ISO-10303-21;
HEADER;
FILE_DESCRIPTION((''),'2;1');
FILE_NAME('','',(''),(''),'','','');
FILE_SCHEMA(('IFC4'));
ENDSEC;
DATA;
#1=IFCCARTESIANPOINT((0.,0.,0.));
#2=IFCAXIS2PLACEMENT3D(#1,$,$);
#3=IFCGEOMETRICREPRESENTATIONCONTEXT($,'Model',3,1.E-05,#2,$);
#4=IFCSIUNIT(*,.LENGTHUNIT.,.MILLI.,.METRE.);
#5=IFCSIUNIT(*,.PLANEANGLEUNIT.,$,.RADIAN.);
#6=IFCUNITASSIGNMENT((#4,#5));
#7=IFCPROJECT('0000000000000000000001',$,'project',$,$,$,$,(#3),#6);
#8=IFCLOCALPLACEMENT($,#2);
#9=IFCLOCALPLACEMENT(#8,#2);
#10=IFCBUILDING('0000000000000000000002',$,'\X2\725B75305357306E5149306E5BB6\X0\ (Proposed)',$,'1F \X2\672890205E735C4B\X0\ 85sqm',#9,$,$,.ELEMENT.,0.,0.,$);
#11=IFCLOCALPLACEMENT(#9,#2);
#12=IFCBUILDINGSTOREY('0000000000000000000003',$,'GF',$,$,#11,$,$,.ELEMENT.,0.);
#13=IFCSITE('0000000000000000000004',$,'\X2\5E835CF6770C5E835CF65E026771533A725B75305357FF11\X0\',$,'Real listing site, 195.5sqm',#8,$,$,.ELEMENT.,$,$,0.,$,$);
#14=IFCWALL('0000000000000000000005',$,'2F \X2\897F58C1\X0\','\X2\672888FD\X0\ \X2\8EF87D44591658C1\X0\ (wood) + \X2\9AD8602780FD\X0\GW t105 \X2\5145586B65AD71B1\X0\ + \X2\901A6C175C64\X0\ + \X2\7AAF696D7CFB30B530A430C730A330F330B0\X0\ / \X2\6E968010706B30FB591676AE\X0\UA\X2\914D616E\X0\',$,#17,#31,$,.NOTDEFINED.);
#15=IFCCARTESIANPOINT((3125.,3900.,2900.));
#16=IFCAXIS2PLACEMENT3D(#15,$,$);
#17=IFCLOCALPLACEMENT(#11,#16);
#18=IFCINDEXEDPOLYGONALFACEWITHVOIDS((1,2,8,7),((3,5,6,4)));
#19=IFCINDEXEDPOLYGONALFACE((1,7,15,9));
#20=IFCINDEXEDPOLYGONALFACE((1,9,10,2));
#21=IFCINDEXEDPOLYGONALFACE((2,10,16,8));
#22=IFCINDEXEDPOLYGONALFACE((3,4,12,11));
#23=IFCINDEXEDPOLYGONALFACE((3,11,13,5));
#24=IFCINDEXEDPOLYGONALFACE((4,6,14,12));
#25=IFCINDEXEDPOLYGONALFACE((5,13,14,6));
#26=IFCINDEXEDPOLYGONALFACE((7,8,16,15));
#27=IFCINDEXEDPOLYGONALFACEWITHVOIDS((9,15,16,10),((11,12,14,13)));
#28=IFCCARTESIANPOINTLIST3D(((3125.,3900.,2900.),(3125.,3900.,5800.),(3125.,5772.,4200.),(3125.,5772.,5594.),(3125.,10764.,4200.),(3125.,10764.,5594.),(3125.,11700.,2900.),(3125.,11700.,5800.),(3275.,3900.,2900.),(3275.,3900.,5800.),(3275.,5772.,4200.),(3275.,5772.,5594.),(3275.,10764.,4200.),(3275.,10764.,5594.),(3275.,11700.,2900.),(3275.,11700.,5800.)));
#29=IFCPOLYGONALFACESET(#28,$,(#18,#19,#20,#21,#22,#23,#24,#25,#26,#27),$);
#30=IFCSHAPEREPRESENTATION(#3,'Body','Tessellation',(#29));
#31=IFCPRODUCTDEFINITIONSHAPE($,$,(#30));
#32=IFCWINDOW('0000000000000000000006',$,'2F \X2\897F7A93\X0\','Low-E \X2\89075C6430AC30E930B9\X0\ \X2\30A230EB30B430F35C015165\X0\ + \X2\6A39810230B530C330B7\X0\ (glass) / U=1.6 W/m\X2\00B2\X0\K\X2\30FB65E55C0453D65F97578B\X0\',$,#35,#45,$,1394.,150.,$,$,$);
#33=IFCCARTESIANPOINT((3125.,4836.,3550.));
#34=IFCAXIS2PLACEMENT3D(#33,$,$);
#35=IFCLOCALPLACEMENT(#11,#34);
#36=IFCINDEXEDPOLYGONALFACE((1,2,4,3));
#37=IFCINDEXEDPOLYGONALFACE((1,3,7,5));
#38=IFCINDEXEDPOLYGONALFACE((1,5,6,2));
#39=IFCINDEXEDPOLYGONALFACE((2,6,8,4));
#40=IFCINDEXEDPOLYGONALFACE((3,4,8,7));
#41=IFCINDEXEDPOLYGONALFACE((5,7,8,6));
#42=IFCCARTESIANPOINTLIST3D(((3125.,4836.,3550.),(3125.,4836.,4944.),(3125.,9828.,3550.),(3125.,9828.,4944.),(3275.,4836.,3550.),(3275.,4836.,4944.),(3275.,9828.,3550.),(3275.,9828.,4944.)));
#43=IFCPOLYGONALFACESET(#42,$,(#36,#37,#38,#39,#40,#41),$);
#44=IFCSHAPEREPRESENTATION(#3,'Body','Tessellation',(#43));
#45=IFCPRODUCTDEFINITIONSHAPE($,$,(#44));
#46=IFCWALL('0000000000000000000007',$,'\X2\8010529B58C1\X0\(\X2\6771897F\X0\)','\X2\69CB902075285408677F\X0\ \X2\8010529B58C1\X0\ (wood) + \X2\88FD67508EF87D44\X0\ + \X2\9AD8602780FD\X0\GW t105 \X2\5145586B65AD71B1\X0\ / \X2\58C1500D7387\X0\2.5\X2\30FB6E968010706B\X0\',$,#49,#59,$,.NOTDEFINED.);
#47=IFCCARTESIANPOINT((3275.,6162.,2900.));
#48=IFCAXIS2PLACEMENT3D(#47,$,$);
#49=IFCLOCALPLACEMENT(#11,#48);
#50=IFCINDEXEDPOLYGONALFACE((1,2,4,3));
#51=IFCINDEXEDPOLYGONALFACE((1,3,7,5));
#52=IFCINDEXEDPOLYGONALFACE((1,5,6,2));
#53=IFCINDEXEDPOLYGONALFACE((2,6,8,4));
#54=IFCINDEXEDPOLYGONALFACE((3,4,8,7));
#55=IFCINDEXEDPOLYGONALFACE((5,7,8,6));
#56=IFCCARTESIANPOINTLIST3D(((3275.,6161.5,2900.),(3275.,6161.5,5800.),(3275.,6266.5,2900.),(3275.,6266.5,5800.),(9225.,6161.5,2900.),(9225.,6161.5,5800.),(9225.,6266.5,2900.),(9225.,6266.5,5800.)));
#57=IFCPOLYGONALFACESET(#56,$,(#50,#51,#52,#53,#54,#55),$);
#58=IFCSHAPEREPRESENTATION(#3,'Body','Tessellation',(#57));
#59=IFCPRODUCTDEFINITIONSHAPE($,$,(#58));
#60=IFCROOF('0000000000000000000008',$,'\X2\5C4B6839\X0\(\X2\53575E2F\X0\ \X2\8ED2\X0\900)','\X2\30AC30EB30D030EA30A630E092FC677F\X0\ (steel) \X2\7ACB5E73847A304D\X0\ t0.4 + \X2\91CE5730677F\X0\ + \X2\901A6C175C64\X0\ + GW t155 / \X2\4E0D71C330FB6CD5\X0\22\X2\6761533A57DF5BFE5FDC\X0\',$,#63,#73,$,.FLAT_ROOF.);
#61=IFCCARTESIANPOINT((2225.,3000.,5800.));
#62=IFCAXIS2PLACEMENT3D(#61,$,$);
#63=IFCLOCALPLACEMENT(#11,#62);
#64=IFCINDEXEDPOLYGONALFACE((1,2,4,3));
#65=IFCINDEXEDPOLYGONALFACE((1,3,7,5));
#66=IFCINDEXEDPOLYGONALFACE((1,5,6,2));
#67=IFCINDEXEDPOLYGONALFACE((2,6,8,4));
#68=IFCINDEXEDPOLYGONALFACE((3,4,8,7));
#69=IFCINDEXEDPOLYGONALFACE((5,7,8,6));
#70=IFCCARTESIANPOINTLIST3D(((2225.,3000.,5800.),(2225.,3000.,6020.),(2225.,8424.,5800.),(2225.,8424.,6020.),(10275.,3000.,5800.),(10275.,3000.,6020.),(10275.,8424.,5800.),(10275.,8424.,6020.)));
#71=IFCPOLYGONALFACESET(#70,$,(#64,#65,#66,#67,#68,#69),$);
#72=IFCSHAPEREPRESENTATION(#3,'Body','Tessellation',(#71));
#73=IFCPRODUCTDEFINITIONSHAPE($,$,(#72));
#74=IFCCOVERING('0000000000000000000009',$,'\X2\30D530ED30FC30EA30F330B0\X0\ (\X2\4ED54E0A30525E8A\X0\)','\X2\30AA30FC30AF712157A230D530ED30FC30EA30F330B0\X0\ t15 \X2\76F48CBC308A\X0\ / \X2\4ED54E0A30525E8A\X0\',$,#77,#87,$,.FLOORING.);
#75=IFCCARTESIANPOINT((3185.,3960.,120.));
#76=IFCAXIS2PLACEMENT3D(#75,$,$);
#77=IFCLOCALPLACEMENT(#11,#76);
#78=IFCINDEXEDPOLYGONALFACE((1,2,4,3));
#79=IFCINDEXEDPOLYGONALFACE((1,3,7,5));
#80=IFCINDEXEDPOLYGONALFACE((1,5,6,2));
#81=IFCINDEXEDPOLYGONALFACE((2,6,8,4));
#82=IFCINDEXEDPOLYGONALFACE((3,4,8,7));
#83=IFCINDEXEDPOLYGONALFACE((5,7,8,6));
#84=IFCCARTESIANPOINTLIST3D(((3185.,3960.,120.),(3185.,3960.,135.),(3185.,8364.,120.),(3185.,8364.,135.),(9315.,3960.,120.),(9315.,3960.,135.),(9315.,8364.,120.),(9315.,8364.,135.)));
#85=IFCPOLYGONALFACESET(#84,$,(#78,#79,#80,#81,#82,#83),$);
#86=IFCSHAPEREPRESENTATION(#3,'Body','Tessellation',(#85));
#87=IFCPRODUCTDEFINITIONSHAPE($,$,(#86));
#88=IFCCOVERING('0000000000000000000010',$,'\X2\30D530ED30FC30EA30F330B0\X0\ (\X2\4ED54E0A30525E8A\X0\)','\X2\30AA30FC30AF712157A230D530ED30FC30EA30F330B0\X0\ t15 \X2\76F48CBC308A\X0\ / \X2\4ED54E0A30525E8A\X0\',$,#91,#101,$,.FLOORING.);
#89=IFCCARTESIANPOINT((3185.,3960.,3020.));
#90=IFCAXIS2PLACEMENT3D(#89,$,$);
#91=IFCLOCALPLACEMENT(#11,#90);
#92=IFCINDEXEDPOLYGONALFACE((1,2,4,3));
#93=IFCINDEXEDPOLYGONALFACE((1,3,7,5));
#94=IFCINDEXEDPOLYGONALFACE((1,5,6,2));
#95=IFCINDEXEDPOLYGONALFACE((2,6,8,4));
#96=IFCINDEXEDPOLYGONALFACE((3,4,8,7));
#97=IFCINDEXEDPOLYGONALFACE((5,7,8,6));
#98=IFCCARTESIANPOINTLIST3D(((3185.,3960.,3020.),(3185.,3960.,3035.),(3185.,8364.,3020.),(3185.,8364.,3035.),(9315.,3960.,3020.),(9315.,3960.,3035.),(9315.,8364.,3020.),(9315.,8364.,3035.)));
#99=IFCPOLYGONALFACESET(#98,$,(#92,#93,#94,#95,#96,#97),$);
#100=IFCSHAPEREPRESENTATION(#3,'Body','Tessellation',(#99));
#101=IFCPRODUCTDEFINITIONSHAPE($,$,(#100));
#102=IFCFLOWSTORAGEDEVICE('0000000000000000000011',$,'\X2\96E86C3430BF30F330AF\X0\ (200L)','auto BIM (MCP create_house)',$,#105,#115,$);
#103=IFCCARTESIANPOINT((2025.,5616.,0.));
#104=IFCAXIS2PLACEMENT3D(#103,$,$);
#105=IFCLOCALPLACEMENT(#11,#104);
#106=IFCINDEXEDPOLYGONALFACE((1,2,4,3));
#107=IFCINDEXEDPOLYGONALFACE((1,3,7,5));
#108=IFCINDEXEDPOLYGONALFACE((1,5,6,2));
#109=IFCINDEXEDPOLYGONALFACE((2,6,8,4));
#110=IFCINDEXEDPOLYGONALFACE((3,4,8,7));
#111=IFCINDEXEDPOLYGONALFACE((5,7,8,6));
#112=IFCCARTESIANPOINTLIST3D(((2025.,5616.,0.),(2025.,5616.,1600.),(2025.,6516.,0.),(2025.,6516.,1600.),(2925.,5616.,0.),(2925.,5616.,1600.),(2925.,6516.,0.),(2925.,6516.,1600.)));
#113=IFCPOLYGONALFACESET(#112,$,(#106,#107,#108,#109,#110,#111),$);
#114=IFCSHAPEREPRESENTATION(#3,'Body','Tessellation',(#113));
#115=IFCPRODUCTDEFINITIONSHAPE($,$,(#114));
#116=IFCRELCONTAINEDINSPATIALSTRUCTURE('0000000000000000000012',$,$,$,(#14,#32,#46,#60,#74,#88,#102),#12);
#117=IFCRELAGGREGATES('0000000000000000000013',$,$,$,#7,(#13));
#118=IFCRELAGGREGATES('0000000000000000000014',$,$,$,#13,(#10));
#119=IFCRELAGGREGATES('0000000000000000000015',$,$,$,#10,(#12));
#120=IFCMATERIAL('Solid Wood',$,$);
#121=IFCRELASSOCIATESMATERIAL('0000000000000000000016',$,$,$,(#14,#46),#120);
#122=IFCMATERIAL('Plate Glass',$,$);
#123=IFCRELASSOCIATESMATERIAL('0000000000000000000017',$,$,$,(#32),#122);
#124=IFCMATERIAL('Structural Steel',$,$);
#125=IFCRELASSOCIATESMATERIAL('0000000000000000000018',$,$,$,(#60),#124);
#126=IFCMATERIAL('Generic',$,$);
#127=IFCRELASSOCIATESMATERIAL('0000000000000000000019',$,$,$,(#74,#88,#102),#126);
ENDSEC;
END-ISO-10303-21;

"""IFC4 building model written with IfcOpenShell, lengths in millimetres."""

from ifc_helpers import new_model, si_unit, frame, frame_2d, origin, place, context, project, spatial, rectangle, extrude, material, element, fill, save


model = new_model("IFC4")

# Units and contexts
model_context = context("Model", 3, precision=1e-05, world=origin())
ifc_project = project(units=[si_unit("LENGTHUNIT", "METRE", prefix="MILLI"), si_unit("PLANEANGLEUNIT", "RADIAN")], contexts=[model_context])

# Site, building, storey
site_placement = place(None, origin())
site = spatial("IfcSite", under=ifc_project, at=site_placement, Name="広島県広島市東区牛田南１", ObjectType="Real listing site, 195.5sqm", CompositionType="ELEMENT", RefElevation=0.0)
building_placement = place(site_placement, origin())
building = spatial("IfcBuilding", under=site, at=building_placement, Name="牛田南の光の家 (Proposed)", ObjectType="1F 木造平屋 85sqm", CompositionType="ELEMENT", ElevationOfRefHeight=0.0, ElevationOfTerrain=0.0)
storey_placement = place(building_placement, origin())
storey = spatial("IfcBuildingStorey", under=building, at=storey_placement, Name="GF", CompositionType="ELEMENT", Elevation=0.0)

# Shared definitions
ifc_material_1 = material(Name="Solid Wood")
ifc_material_2 = material(Name="Generic")

# Shared definitions
ifc_material_3 = material(Name="Plate Glass")

# Wall, opening, window
wall_1_placement = place(storey_placement, frame((3125.0, 3900.0, 2900.0)))
wall_1 = element("IfcWall", 1, at=wall_1_placement, inside=storey, material=ifc_material_1, Name="2F 西壁", Description="木製 軸組外壁 (wood) + 高性能GW t105 充填断熱 + 通気層 + 窯業系サイディング / 準耐火・外皮UA配慮", PredefinedType="NOTDEFINED", context=model_context, shape_type="SweptSolid", body=[
    extrude(rectangle(XDim=150.0, YDim=7800.0, at=frame_2d((75.0, 3900.0))), frame((3125.0, 3900.0, 2900.0)), (0.0, 0.0, 1.0), 2900.0),
])
opening_1_placement = place(storey_placement, frame((3125.0, 4836.0, 3550.0)))
opening_1 = element("IfcOpeningElement", 2, at=opening_1_placement, cuts=wall_1, PredefinedType="NOTDEFINED", context=model_context, shape_type="SweptSolid", body=[
    extrude(rectangle(XDim=150.0, YDim=4992.0, at=frame_2d((75.0, 2496.0))), frame((3125.0, 4836.0, 3550.0)), (0.0, 0.0, 1.0), 1394.0),
])
window_1_placement = place(storey_placement, frame((3125.0, 4836.0, 3550.0)))
window_1 = element("IfcWindow", 3, at=window_1_placement, inside=storey, material=ifc_material_3, Name="2F 西窓", Description="Low-E 複層ガラス アルゴン封入 + 樹脂サッシ (glass) / U=1.6 W/m²K・日射取得型", OverallHeight=1394.0, OverallWidth=150.0, context=model_context, shape_type="SweptSolid", body=[
    extrude(rectangle(XDim=150.0, YDim=4992.0, at=frame_2d((75.0, 2496.0))), frame((3125.0, 4836.0, 3550.0)), (0.0, 0.0, 1.0), 1394.0),
])
fill(opening_1, window_1)

# Wall
wall_2_placement = place(storey_placement, frame((3275.0, 6162.0, 2900.0)))
element("IfcWall", 4, at=wall_2_placement, inside=storey, material=ifc_material_1, Name="耐力壁(東西)", Description="構造用合板 耐力壁 (wood) + 製材軸組 + 高性能GW t105 充填断熱 / 壁倍率2.5・準耐火", PredefinedType="NOTDEFINED", context=model_context, shape_type="SweptSolid", body=[
    extrude(rectangle(XDim=5950.0, YDim=105.0, at=frame_2d((2975.0, 52.0))), frame((3275.0, 6162.0, 2900.0)), (0.0, 0.0, 1.0), 2900.0),
])

# Roof
ifc_material_4 = material(Name="Structural Steel")
for number, where, name in (
    (5, (2225.0, 3000.0, 5800.0), "屋根(南帯 軒900)"),
):
    element("IfcRoof", number, at=place(storey_placement, frame(where)), inside=storey, material=ifc_material_4, Name=name, Description="ガルバリウム鋼板 (steel) 立平葺き t0.4 + 野地板 + 通気層 + GW t155 / 不燃・法22条区域対応", PredefinedType="FLAT_ROOF", context=model_context, shape_type="SweptSolid", body=[
        extrude(rectangle(XDim=8050.0, YDim=5424.0, at=frame_2d((4025.0, 2712.0))), frame((2225.0, 3000.0, 5800.0)), (0.0, 0.0, 1.0), 220.0),
    ])

# Coverings
covering_1_placement = place(storey_placement, frame((3185.0, 3960.0, 120.0)))
element("IfcCovering", 6, at=covering_1_placement, inside=storey, material=ifc_material_2, Name="フローリング (仕上げ床)", Description="オーク無垢フローリング t15 直貼り / 仕上げ床", PredefinedType="FLOORING", context=model_context, shape_type="SweptSolid", body=[
    extrude(rectangle(XDim=6130.0, YDim=4404.0, at=frame_2d((3065.0, 2202.0))), frame((3185.0, 3960.0, 120.0)), (0.0, 0.0, 1.0), 15.0),
])
covering_2_placement = place(storey_placement, frame((3185.0, 3960.0, 3020.0)))
element("IfcCovering", 7, at=covering_2_placement, inside=storey, material=ifc_material_2, Name="フローリング (仕上げ床)", Description="オーク無垢フローリング t15 直貼り / 仕上げ床", PredefinedType="FLOORING", context=model_context, shape_type="SweptSolid", body=[
    extrude(rectangle(XDim=6130.0, YDim=4404.0, at=frame_2d((3065.0, 2202.0))), frame((3185.0, 3960.0, 3020.0)), (0.0, 0.0, 1.0), 15.0),
])

# Flow storage device
flow_storage_device_placement = place(storey_placement, frame((2025.0, 5616.0, 0.0)))
element("IfcFlowStorageDevice", 8, at=flow_storage_device_placement, inside=storey, material=ifc_material_2, Name="雨水タンク (200L)", Description="auto BIM (MCP create_house)", context=model_context, shape_type="SweptSolid", body=[
    extrude(rectangle(XDim=900.0, YDim=900.0, at=frame_2d((450.0, 450.0))), frame((2025.0, 5616.0, 0.0)), (0.0, 0.0, 1.0), 1600.0),
])

save(model, "model.ifc")
